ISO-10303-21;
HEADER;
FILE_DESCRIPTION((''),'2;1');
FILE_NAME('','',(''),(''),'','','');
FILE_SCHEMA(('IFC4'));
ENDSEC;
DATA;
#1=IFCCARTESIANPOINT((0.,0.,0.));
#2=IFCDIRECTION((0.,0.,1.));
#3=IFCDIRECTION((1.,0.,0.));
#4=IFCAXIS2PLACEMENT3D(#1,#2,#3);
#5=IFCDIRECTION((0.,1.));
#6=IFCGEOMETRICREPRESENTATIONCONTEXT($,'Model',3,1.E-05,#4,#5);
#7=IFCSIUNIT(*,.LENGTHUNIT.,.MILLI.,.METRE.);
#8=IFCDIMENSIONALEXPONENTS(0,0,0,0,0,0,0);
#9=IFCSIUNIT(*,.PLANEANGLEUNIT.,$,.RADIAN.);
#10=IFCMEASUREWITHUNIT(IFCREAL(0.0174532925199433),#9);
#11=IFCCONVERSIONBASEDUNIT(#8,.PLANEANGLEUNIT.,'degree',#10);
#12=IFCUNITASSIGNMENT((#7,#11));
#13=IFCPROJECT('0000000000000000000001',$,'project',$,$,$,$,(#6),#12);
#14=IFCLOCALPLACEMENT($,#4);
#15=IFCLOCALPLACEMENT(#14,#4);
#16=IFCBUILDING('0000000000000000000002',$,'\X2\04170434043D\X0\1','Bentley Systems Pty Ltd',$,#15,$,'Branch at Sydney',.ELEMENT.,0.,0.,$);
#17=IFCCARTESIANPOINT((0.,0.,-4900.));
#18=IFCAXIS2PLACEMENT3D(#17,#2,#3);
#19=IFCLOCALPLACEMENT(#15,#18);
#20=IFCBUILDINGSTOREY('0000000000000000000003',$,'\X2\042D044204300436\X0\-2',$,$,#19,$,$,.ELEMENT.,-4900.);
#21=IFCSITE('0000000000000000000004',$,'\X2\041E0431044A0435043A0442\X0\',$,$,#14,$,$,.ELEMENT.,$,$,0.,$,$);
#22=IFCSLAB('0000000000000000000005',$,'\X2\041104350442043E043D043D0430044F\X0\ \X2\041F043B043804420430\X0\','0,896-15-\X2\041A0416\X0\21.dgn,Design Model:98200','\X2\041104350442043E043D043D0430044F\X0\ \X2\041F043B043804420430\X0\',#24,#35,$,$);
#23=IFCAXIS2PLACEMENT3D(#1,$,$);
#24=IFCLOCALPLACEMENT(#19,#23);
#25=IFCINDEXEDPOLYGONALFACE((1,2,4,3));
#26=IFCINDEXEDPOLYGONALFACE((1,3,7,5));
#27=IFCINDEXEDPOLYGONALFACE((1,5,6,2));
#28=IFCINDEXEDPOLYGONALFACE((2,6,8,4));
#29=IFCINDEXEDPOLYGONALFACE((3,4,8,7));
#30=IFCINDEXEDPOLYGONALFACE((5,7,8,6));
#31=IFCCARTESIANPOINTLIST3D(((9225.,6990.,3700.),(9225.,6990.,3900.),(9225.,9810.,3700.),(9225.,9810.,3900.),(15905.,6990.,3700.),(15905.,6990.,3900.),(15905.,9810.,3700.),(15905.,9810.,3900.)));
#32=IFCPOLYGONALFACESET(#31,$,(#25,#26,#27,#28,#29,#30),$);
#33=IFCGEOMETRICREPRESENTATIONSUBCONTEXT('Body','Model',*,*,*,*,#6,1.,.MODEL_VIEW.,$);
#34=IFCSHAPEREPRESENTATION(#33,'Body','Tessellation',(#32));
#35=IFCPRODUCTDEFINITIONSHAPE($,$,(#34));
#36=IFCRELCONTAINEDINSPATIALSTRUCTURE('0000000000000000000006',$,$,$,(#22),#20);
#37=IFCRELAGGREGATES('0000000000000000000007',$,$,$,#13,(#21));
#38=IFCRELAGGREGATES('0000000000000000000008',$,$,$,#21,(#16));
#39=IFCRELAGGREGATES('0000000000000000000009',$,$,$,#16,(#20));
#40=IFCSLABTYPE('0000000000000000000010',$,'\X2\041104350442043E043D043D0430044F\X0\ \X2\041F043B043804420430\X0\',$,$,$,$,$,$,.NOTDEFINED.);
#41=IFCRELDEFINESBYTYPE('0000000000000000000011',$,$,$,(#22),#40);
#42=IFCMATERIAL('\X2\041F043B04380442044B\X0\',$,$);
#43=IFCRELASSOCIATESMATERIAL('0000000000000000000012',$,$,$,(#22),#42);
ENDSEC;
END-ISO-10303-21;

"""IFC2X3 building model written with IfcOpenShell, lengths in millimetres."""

from ifc_helpers import new_model, entity, si_unit, converted_unit, direction, frame, frame_2d, origin_with_axes, place, context, subcontext, project, spatial, rectangle, extrude, material, type_object, element, save


model = new_model("IFC2X3")

# Units and contexts
model_context = context("Model", 3, precision=1e-05, world=origin_with_axes(), true_north=direction((0.0, 1.0)))
body_context = subcontext(model_context, "Body", "Model", "MODEL_VIEW", scale=1.0)
ifc_project = project(units=[si_unit("LENGTHUNIT", "METRE", prefix="MILLI"), converted_unit("PLANEANGLEUNIT", "degree", entity("IfcReal", 0.0174532925199433), si_unit("PLANEANGLEUNIT", "RADIAN"), dimensions=[0, 0, 0, 0, 0, 0, 0])], contexts=[model_context])

# Site, building, storey
site_placement = place(None, origin_with_axes())
site = spatial("IfcSite", under=ifc_project, at=site_placement, Name="Объект", CompositionType="ELEMENT", RefElevation=0.0)
building_placement = place(site_placement, origin_with_axes())
building = spatial("IfcBuilding", under=site, at=building_placement, Name="Здн1", Description="Bentley Systems Pty Ltd", LongName="Branch at Sydney", CompositionType="ELEMENT", ElevationOfRefHeight=0.0, ElevationOfTerrain=0.0)
storey_placement = place(building_placement, frame((0.0, 0.0, -4900.0), z_axis=(0.0, 0.0, 1.0), x_axis=(1.0, 0.0, 0.0)))
storey = spatial("IfcBuildingStorey", under=building, at=storey_placement, Name="Этаж-2", CompositionType="ELEMENT", Elevation=-4900.0)

# Slab
ifc_material_1 = material(Name="Плиты")
slab_type = type_object("IfcSlabType", Name="Бетонная Плита", PredefinedType="NOTDEFINED")
slab_1_placement = place(storey_placement, frame((15905.0, 9810.0, 3900.0), z_axis=(0.0, 0.0, -1.0), x_axis=(0.0, -1.0, 0.0)))
element("IfcSlab", 1, at=slab_1_placement, inside=storey, type_object=slab_type, material=ifc_material_1, Name="Бетонная Плита", Description="0,896-15-КЖ21.dgn,Design Model:98200", ObjectType="Бетонная Плита", context=body_context, shape_type="SweptSolid", body=[
    extrude(rectangle(XDim=2820.0, YDim=6680.0, at=frame_2d((1410.0, 3340.0), x_axis=(1.0, 0.0))), origin_with_axes(), (0.0, 0.0, 1.0), 200.0),
])

save(model, "model.ifc")
